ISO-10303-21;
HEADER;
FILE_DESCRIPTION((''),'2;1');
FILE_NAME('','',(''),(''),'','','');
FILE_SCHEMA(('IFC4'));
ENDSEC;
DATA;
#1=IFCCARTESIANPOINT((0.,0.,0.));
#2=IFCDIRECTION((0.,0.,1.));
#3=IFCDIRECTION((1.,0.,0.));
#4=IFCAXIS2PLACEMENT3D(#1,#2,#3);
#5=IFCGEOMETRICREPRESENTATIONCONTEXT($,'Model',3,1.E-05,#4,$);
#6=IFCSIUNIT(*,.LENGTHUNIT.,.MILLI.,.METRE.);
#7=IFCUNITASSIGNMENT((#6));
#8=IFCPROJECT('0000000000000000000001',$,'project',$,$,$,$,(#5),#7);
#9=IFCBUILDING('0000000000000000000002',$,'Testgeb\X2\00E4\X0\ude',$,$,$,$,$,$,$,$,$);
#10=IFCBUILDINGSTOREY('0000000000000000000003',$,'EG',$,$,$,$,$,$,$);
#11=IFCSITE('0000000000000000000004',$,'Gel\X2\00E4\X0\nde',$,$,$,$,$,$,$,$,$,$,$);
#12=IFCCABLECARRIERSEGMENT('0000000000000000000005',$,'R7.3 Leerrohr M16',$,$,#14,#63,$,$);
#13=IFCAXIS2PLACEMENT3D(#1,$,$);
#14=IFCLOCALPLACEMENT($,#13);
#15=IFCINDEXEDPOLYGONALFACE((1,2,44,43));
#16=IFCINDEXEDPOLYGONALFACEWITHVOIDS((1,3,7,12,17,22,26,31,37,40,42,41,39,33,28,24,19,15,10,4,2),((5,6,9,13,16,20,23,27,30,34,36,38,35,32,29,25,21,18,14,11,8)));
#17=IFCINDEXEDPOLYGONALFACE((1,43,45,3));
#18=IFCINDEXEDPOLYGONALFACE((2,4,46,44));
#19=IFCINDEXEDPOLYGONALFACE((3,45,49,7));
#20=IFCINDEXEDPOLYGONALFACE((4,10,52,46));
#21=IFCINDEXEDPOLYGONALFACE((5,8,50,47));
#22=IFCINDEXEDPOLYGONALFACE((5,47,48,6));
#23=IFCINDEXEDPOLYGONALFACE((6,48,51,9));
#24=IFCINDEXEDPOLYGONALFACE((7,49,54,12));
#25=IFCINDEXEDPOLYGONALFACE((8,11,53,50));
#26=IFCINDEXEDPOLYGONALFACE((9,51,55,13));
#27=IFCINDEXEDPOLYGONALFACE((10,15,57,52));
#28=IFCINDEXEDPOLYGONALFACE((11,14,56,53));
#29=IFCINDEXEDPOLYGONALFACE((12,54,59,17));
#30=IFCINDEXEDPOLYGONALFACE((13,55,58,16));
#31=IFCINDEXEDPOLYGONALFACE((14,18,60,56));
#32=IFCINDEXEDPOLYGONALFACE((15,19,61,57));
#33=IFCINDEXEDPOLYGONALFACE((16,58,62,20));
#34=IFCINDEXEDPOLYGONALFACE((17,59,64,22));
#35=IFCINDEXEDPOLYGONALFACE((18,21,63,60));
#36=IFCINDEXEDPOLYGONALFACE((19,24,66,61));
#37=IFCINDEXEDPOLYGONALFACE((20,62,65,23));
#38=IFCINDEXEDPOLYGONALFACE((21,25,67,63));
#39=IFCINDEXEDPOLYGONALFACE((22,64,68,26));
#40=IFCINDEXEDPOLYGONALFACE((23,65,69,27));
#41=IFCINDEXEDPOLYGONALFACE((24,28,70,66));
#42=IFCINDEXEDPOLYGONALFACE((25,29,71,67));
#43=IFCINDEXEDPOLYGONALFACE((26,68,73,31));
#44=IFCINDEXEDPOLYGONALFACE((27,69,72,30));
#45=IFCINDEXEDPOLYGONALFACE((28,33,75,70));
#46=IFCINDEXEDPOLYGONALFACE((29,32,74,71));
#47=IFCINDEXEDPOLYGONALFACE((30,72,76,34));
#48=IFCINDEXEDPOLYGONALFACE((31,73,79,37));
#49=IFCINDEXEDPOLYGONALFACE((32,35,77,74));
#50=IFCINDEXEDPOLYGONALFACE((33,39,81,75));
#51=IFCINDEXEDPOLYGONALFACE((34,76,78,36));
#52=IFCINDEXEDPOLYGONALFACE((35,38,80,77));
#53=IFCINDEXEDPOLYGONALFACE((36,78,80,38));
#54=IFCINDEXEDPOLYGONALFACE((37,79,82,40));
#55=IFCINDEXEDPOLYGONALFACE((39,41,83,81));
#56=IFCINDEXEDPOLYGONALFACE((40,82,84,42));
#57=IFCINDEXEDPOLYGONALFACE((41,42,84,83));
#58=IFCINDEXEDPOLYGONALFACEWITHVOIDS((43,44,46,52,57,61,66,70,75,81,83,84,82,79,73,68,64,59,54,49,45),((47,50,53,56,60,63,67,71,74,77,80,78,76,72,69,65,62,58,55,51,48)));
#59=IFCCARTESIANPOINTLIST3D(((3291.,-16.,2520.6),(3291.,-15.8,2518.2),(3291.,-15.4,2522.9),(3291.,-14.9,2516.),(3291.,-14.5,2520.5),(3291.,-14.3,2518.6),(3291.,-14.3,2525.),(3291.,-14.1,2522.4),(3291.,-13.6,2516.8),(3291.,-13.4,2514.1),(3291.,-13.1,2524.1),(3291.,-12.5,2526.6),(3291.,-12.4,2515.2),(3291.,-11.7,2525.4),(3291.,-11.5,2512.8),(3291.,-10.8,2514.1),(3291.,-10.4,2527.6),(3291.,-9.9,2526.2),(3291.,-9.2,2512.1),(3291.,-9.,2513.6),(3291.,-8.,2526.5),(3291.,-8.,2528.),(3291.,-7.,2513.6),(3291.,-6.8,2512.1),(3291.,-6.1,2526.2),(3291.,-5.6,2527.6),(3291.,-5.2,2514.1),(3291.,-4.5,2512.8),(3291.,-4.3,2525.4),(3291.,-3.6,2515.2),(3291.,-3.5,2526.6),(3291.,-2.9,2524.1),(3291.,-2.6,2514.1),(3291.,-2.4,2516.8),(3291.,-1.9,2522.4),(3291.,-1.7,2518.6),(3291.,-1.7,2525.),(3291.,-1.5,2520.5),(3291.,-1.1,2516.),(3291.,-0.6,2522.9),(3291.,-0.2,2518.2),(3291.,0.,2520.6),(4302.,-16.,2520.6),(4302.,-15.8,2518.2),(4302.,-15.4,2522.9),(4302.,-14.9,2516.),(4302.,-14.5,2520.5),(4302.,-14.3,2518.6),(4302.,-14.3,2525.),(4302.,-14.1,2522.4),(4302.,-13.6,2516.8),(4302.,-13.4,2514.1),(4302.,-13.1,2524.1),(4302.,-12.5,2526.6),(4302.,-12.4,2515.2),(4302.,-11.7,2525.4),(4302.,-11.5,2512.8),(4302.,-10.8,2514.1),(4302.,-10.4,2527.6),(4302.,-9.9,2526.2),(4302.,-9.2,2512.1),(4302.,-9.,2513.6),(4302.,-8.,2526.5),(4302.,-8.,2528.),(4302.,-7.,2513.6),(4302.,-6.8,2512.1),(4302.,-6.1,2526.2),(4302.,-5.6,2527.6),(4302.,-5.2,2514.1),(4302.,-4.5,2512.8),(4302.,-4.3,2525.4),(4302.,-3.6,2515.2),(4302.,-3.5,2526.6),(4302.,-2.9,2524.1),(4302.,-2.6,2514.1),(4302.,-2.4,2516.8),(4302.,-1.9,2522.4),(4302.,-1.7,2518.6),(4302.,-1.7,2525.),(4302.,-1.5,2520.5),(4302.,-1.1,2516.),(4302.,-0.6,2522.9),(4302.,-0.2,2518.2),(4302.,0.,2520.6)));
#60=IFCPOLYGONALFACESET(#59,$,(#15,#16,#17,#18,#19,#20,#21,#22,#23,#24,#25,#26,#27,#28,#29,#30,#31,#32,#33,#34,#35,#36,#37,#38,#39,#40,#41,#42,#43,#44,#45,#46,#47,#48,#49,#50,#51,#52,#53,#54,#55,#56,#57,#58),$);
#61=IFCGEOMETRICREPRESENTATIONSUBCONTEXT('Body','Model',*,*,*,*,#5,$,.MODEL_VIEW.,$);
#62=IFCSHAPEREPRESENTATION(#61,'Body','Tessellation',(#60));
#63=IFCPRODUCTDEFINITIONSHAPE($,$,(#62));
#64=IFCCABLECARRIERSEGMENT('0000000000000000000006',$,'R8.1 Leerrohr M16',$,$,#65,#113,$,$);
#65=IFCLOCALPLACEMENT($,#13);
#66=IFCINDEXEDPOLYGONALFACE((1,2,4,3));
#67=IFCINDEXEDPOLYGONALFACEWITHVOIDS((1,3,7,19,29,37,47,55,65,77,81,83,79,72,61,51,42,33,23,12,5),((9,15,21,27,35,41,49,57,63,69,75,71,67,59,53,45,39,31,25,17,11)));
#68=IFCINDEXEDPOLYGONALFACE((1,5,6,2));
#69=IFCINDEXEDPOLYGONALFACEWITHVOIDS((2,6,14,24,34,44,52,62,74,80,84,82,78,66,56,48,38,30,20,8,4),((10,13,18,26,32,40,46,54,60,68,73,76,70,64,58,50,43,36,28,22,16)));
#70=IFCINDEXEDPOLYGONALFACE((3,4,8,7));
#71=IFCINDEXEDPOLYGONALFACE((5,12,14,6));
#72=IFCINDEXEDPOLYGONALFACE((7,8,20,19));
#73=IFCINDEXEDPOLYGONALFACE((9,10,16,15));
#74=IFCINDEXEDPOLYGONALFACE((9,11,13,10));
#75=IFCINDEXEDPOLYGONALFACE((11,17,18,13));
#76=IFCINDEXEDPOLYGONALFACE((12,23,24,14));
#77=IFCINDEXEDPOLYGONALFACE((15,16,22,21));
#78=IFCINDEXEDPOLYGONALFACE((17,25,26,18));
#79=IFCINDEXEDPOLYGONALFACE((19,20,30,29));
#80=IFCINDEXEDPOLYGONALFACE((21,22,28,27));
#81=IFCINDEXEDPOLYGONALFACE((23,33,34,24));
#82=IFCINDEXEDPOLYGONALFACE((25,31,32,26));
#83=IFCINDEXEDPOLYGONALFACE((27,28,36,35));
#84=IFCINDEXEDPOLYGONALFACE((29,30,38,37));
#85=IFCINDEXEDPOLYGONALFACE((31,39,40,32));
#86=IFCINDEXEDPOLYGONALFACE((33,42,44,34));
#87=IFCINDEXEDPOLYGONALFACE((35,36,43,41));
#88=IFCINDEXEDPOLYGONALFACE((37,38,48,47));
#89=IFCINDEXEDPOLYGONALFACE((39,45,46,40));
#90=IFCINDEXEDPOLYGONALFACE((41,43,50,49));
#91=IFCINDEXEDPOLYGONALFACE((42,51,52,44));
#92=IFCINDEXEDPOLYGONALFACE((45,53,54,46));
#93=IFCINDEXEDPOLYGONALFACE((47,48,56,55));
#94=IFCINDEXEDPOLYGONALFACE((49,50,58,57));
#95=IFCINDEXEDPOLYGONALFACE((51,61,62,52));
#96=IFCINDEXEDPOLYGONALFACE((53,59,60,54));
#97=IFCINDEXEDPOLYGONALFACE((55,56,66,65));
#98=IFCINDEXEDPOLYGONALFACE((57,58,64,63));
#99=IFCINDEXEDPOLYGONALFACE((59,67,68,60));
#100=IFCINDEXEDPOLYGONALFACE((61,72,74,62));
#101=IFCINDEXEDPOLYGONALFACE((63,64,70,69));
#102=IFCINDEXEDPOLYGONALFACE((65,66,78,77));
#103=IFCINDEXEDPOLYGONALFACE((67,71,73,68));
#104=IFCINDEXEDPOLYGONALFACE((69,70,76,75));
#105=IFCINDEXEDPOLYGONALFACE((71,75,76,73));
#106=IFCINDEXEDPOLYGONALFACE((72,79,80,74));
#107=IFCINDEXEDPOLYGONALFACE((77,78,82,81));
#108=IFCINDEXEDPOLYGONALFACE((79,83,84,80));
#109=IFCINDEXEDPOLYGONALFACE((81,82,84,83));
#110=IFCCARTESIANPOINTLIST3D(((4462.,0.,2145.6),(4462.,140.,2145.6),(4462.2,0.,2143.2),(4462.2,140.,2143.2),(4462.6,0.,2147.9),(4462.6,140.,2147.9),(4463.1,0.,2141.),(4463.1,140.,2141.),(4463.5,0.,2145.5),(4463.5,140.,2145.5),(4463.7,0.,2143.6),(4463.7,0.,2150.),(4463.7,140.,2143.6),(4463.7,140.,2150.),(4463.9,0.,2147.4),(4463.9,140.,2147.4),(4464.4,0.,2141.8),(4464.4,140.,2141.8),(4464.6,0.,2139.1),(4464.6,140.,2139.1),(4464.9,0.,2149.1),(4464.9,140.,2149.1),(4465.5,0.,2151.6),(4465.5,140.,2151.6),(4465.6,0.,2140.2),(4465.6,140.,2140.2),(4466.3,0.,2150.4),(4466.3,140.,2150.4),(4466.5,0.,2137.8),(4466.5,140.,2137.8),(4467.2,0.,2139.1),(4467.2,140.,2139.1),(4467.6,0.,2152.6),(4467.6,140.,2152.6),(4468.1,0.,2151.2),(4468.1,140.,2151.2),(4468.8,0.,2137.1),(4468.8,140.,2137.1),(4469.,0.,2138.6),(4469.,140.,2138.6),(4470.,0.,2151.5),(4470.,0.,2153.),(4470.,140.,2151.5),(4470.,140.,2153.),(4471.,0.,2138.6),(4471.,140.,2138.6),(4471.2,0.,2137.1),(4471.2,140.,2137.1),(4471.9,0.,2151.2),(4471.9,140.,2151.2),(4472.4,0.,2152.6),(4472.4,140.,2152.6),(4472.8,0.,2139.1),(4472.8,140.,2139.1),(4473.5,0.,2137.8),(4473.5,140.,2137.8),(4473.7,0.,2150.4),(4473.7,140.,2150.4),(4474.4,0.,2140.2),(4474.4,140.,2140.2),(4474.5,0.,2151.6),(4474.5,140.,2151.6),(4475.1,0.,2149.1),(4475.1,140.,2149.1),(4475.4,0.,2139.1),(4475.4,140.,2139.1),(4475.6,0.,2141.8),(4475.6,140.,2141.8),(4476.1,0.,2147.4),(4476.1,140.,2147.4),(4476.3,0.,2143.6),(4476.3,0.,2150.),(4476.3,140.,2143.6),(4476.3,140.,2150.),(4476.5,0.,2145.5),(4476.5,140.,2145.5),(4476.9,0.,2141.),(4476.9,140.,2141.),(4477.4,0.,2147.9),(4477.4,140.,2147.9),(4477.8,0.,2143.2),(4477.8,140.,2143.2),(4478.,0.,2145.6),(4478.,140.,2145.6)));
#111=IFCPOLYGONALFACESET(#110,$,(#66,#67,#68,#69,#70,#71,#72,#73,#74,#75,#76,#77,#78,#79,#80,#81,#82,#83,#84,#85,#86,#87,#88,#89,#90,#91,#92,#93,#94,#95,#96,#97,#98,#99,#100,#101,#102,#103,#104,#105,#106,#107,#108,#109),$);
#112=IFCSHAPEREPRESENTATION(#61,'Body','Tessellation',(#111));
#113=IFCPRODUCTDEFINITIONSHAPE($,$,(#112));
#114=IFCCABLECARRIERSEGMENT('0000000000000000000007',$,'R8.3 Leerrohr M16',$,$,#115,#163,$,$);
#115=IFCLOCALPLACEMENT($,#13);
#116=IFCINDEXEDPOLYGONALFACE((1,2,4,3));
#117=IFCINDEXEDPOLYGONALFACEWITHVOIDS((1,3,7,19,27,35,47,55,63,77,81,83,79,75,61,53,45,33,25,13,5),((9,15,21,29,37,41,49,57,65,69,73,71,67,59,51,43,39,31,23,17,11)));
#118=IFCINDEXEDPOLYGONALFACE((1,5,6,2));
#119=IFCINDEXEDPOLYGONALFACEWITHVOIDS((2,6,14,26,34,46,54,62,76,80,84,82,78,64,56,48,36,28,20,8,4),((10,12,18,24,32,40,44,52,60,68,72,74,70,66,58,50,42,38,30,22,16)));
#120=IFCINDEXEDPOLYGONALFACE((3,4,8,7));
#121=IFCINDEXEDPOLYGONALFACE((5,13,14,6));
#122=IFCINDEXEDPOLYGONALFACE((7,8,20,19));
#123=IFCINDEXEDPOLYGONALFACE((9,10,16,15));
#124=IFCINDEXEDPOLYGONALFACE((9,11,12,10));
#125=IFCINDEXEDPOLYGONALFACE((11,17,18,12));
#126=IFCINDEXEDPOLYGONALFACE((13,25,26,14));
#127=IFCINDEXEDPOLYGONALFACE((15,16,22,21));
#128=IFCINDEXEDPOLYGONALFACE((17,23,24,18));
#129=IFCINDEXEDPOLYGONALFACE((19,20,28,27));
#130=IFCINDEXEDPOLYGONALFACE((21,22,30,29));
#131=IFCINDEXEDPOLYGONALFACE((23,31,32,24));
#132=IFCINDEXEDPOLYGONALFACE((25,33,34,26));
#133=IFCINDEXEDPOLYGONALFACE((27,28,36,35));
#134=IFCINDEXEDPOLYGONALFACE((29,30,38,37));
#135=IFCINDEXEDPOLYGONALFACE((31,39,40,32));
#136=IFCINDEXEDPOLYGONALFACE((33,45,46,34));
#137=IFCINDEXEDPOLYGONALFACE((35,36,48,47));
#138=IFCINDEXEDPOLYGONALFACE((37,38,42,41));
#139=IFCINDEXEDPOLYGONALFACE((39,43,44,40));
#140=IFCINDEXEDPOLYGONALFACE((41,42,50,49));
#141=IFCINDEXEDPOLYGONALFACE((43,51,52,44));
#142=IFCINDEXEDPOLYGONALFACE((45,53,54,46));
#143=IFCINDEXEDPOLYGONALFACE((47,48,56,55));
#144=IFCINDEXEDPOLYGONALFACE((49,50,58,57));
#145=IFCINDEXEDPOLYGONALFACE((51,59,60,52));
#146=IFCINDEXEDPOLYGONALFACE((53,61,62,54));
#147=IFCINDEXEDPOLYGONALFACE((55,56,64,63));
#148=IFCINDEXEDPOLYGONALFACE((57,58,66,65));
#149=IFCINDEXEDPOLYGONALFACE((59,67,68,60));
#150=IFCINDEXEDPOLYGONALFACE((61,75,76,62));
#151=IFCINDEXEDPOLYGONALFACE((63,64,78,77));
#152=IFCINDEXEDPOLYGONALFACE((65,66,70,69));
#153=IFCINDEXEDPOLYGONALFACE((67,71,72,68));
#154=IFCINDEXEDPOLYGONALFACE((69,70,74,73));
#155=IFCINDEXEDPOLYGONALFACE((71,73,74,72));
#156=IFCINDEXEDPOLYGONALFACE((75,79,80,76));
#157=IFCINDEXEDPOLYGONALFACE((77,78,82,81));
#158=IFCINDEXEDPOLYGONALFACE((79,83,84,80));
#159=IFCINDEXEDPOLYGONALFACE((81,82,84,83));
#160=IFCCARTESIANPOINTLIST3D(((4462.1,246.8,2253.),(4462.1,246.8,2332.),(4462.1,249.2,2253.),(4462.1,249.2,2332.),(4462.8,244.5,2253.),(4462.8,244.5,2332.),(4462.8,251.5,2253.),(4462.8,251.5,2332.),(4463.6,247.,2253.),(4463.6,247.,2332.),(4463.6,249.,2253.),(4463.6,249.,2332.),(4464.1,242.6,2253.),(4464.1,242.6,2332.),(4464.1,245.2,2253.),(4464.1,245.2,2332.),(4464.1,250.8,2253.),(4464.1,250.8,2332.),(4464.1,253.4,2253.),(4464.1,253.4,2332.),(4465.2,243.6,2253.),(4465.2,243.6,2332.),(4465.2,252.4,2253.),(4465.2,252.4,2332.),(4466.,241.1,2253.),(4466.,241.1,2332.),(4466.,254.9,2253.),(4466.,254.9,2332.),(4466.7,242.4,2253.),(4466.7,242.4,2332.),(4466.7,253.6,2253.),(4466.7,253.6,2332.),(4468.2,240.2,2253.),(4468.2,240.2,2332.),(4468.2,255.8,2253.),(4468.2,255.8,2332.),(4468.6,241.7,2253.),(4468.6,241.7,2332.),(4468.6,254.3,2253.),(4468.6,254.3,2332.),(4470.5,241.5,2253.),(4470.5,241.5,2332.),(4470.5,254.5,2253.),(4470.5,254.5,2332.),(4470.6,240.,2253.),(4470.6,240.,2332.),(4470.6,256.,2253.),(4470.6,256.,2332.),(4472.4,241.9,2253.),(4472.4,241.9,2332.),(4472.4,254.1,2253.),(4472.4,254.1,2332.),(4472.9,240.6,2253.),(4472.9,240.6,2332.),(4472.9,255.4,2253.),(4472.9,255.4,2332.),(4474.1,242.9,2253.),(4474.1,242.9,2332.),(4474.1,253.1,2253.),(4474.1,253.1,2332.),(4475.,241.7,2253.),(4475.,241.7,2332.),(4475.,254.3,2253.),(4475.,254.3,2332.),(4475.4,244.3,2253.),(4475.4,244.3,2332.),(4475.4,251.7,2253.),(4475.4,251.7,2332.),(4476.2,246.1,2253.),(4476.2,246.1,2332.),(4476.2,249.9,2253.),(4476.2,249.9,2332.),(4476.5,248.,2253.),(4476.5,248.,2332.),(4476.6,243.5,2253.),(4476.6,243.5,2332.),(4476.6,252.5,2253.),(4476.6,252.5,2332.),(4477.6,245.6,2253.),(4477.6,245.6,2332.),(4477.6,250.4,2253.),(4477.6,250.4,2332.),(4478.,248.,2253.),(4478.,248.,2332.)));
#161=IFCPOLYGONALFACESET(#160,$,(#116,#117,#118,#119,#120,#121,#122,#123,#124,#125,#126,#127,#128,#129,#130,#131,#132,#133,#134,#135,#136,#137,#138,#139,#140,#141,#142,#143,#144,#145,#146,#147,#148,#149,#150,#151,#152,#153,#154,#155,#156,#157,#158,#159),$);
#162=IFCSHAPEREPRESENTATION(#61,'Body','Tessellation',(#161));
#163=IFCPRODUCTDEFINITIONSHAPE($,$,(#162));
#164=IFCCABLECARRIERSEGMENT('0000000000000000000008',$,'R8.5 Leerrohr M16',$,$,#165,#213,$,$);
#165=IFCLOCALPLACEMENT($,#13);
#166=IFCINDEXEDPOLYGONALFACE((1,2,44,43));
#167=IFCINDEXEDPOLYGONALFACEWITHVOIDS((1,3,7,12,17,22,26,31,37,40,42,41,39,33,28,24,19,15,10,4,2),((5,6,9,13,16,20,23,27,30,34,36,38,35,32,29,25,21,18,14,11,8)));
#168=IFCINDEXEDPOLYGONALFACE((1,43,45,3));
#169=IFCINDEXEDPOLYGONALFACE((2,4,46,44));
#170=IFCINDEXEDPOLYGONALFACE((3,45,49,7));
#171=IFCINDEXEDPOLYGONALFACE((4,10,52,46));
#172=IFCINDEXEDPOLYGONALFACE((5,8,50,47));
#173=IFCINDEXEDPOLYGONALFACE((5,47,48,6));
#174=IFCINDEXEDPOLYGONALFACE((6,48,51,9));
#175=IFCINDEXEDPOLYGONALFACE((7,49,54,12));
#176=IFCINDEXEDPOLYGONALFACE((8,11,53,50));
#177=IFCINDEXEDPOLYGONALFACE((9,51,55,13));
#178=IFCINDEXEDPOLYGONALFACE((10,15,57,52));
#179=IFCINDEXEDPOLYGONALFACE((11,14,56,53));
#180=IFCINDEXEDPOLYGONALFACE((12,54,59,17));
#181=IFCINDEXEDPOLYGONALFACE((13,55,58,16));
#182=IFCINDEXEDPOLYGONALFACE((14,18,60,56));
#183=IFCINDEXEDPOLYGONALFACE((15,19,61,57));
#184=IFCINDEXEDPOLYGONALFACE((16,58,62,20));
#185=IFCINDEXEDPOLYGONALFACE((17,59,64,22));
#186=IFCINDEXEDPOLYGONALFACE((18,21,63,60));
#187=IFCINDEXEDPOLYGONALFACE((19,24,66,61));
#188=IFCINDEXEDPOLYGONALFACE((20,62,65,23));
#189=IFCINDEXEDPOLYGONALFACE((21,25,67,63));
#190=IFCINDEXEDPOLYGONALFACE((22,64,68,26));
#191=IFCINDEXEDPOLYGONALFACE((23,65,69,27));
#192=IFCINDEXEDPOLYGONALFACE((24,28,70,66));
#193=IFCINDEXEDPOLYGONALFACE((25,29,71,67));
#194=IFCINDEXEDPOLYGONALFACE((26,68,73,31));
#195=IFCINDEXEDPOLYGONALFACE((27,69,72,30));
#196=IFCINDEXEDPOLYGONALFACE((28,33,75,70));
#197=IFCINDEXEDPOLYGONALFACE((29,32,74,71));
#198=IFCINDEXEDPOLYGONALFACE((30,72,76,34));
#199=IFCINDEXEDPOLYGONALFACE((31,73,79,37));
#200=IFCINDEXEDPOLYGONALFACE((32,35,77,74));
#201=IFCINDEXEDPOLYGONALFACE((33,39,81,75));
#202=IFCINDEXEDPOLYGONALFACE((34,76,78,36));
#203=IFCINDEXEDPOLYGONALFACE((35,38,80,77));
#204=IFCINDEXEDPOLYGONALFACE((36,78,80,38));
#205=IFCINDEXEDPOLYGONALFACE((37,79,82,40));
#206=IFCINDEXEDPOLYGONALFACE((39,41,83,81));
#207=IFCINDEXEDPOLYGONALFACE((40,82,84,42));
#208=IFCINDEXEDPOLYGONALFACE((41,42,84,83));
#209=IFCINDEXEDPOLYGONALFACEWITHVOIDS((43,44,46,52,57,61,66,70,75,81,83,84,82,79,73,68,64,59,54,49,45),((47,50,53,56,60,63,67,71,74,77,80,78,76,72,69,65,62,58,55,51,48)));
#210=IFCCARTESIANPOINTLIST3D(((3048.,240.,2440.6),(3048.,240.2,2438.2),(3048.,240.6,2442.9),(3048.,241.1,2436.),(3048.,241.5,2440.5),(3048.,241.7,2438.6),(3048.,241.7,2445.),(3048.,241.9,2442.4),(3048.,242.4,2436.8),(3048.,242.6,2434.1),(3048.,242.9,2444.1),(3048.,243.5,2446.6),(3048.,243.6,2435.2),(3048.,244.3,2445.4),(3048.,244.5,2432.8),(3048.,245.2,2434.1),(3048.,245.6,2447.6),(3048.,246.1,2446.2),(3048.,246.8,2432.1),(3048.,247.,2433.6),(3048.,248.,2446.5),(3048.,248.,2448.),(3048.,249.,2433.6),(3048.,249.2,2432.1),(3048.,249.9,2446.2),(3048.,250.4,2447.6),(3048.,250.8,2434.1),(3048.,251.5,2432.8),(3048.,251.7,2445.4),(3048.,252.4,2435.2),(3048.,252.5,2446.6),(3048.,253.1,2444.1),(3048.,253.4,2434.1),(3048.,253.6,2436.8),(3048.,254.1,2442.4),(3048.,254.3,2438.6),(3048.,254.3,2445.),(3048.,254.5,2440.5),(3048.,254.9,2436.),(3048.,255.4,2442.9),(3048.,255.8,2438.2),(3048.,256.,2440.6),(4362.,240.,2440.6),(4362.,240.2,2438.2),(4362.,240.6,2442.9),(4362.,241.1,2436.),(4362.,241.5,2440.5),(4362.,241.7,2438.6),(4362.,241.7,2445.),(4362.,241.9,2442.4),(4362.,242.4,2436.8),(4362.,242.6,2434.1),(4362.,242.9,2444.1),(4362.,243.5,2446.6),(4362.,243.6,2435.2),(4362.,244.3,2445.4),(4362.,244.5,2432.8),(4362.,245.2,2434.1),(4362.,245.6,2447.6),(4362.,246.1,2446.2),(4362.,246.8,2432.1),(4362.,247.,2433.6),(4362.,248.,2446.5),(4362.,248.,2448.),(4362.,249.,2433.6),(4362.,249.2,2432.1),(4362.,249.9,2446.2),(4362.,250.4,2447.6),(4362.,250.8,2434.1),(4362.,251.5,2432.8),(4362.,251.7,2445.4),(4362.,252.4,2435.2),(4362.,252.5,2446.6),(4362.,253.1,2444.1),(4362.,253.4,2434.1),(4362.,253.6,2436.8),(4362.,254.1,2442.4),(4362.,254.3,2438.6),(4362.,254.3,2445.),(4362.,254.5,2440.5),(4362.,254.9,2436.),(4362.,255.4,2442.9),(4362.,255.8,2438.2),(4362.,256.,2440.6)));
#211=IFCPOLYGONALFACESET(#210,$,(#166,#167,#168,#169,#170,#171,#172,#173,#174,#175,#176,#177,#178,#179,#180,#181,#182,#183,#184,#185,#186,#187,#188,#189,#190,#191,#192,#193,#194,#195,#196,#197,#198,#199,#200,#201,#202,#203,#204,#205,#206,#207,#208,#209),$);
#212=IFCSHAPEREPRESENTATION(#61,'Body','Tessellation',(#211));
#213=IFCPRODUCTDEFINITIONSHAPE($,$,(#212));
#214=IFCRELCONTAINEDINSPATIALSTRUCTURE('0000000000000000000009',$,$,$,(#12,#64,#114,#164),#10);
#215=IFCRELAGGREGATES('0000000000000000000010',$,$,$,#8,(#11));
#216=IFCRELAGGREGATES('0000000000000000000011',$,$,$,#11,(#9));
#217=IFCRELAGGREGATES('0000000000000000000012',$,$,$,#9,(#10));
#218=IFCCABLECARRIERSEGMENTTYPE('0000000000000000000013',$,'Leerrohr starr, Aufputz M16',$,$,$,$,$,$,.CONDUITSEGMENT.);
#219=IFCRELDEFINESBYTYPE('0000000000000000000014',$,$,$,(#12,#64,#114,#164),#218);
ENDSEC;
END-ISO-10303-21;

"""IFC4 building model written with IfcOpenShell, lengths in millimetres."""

from ifc_helpers import new_model, si_unit, frame, origin_with_axes, place, context, subcontext, project, spatial, hollow_circle, extrude, type_object, element, save


model = new_model("IFC4")

# Units and contexts
model_context = context("Model", 3, precision=1e-05, world=origin_with_axes())
body_context = subcontext(model_context, "Body", "Model", "MODEL_VIEW")
ifc_project = project(units=[si_unit("LENGTHUNIT", "METRE", prefix="MILLI")], contexts=[model_context])

# Site, building, storey
site = spatial("IfcSite", under=ifc_project, Name="Gelände")
building = spatial("IfcBuilding", under=site, Name="Testgebäude")
storey = spatial("IfcBuildingStorey", under=building, Name="EG")

# Cable carrier segments
cable_carrier_segment_type_1 = type_object("IfcCableCarrierSegmentType", Name="Leerrohr starr, Aufputz M16", PredefinedType="CONDUITSEGMENT")
cable_carrier_segment_1_placement = place(None, frame((4302.0, -8.0, 2520.0), z_axis=(-1.0, 0.0, 0.0), x_axis=(0.0, 0.0, 1.0)))
element("IfcCableCarrierSegment", 1, at=cable_carrier_segment_1_placement, inside=storey, type_object=cable_carrier_segment_type_1, Name="R7.3 Leerrohr M16", context=body_context, shape_type="SweptSolid", body=[
    extrude(hollow_circle(Radius=8.0, WallThickness=1.5), None, (0.0, 0.0, 1.0), 1011.0),
])
cable_carrier_segment_2_placement = place(None, frame((4470.0, 0.0, 2145.0), z_axis=(0.0, 1.0, 0.0), x_axis=(0.0, 0.0, 1.0)))
element("IfcCableCarrierSegment", 2, at=cable_carrier_segment_2_placement, inside=storey, type_object=cable_carrier_segment_type_1, Name="R8.1 Leerrohr M16", context=body_context, shape_type="SweptSolid", body=[
    extrude(hollow_circle(Radius=8.0, WallThickness=1.5), None, (0.0, 0.0, 1.0), 140.0),
])
cable_carrier_segment_3_placement = place(None, frame((4470.0, 248.0, 2253.0), z_axis=(0.0, 0.0, 1.0), x_axis=(1.0, 0.0, 0.0)))
element("IfcCableCarrierSegment", 3, at=cable_carrier_segment_3_placement, inside=storey, type_object=cable_carrier_segment_type_1, Name="R8.3 Leerrohr M16", context=body_context, shape_type="SweptSolid", body=[
    extrude(hollow_circle(Radius=8.0, WallThickness=1.5), None, (0.0, 0.0, 1.0), 79.0),
])
cable_carrier_segment_4_placement = place(None, frame((4362.0, 248.0, 2440.0), z_axis=(-1.0, 0.0, 0.0), x_axis=(0.0, 0.0, 1.0)))
element("IfcCableCarrierSegment", 4, at=cable_carrier_segment_4_placement, inside=storey, type_object=cable_carrier_segment_type_1, Name="R8.5 Leerrohr M16", context=body_context, shape_type="SweptSolid", body=[
    extrude(hollow_circle(Radius=8.0, WallThickness=1.5), None, (0.0, 0.0, 1.0), 1314.0),
])

save(model, "model.ifc")
